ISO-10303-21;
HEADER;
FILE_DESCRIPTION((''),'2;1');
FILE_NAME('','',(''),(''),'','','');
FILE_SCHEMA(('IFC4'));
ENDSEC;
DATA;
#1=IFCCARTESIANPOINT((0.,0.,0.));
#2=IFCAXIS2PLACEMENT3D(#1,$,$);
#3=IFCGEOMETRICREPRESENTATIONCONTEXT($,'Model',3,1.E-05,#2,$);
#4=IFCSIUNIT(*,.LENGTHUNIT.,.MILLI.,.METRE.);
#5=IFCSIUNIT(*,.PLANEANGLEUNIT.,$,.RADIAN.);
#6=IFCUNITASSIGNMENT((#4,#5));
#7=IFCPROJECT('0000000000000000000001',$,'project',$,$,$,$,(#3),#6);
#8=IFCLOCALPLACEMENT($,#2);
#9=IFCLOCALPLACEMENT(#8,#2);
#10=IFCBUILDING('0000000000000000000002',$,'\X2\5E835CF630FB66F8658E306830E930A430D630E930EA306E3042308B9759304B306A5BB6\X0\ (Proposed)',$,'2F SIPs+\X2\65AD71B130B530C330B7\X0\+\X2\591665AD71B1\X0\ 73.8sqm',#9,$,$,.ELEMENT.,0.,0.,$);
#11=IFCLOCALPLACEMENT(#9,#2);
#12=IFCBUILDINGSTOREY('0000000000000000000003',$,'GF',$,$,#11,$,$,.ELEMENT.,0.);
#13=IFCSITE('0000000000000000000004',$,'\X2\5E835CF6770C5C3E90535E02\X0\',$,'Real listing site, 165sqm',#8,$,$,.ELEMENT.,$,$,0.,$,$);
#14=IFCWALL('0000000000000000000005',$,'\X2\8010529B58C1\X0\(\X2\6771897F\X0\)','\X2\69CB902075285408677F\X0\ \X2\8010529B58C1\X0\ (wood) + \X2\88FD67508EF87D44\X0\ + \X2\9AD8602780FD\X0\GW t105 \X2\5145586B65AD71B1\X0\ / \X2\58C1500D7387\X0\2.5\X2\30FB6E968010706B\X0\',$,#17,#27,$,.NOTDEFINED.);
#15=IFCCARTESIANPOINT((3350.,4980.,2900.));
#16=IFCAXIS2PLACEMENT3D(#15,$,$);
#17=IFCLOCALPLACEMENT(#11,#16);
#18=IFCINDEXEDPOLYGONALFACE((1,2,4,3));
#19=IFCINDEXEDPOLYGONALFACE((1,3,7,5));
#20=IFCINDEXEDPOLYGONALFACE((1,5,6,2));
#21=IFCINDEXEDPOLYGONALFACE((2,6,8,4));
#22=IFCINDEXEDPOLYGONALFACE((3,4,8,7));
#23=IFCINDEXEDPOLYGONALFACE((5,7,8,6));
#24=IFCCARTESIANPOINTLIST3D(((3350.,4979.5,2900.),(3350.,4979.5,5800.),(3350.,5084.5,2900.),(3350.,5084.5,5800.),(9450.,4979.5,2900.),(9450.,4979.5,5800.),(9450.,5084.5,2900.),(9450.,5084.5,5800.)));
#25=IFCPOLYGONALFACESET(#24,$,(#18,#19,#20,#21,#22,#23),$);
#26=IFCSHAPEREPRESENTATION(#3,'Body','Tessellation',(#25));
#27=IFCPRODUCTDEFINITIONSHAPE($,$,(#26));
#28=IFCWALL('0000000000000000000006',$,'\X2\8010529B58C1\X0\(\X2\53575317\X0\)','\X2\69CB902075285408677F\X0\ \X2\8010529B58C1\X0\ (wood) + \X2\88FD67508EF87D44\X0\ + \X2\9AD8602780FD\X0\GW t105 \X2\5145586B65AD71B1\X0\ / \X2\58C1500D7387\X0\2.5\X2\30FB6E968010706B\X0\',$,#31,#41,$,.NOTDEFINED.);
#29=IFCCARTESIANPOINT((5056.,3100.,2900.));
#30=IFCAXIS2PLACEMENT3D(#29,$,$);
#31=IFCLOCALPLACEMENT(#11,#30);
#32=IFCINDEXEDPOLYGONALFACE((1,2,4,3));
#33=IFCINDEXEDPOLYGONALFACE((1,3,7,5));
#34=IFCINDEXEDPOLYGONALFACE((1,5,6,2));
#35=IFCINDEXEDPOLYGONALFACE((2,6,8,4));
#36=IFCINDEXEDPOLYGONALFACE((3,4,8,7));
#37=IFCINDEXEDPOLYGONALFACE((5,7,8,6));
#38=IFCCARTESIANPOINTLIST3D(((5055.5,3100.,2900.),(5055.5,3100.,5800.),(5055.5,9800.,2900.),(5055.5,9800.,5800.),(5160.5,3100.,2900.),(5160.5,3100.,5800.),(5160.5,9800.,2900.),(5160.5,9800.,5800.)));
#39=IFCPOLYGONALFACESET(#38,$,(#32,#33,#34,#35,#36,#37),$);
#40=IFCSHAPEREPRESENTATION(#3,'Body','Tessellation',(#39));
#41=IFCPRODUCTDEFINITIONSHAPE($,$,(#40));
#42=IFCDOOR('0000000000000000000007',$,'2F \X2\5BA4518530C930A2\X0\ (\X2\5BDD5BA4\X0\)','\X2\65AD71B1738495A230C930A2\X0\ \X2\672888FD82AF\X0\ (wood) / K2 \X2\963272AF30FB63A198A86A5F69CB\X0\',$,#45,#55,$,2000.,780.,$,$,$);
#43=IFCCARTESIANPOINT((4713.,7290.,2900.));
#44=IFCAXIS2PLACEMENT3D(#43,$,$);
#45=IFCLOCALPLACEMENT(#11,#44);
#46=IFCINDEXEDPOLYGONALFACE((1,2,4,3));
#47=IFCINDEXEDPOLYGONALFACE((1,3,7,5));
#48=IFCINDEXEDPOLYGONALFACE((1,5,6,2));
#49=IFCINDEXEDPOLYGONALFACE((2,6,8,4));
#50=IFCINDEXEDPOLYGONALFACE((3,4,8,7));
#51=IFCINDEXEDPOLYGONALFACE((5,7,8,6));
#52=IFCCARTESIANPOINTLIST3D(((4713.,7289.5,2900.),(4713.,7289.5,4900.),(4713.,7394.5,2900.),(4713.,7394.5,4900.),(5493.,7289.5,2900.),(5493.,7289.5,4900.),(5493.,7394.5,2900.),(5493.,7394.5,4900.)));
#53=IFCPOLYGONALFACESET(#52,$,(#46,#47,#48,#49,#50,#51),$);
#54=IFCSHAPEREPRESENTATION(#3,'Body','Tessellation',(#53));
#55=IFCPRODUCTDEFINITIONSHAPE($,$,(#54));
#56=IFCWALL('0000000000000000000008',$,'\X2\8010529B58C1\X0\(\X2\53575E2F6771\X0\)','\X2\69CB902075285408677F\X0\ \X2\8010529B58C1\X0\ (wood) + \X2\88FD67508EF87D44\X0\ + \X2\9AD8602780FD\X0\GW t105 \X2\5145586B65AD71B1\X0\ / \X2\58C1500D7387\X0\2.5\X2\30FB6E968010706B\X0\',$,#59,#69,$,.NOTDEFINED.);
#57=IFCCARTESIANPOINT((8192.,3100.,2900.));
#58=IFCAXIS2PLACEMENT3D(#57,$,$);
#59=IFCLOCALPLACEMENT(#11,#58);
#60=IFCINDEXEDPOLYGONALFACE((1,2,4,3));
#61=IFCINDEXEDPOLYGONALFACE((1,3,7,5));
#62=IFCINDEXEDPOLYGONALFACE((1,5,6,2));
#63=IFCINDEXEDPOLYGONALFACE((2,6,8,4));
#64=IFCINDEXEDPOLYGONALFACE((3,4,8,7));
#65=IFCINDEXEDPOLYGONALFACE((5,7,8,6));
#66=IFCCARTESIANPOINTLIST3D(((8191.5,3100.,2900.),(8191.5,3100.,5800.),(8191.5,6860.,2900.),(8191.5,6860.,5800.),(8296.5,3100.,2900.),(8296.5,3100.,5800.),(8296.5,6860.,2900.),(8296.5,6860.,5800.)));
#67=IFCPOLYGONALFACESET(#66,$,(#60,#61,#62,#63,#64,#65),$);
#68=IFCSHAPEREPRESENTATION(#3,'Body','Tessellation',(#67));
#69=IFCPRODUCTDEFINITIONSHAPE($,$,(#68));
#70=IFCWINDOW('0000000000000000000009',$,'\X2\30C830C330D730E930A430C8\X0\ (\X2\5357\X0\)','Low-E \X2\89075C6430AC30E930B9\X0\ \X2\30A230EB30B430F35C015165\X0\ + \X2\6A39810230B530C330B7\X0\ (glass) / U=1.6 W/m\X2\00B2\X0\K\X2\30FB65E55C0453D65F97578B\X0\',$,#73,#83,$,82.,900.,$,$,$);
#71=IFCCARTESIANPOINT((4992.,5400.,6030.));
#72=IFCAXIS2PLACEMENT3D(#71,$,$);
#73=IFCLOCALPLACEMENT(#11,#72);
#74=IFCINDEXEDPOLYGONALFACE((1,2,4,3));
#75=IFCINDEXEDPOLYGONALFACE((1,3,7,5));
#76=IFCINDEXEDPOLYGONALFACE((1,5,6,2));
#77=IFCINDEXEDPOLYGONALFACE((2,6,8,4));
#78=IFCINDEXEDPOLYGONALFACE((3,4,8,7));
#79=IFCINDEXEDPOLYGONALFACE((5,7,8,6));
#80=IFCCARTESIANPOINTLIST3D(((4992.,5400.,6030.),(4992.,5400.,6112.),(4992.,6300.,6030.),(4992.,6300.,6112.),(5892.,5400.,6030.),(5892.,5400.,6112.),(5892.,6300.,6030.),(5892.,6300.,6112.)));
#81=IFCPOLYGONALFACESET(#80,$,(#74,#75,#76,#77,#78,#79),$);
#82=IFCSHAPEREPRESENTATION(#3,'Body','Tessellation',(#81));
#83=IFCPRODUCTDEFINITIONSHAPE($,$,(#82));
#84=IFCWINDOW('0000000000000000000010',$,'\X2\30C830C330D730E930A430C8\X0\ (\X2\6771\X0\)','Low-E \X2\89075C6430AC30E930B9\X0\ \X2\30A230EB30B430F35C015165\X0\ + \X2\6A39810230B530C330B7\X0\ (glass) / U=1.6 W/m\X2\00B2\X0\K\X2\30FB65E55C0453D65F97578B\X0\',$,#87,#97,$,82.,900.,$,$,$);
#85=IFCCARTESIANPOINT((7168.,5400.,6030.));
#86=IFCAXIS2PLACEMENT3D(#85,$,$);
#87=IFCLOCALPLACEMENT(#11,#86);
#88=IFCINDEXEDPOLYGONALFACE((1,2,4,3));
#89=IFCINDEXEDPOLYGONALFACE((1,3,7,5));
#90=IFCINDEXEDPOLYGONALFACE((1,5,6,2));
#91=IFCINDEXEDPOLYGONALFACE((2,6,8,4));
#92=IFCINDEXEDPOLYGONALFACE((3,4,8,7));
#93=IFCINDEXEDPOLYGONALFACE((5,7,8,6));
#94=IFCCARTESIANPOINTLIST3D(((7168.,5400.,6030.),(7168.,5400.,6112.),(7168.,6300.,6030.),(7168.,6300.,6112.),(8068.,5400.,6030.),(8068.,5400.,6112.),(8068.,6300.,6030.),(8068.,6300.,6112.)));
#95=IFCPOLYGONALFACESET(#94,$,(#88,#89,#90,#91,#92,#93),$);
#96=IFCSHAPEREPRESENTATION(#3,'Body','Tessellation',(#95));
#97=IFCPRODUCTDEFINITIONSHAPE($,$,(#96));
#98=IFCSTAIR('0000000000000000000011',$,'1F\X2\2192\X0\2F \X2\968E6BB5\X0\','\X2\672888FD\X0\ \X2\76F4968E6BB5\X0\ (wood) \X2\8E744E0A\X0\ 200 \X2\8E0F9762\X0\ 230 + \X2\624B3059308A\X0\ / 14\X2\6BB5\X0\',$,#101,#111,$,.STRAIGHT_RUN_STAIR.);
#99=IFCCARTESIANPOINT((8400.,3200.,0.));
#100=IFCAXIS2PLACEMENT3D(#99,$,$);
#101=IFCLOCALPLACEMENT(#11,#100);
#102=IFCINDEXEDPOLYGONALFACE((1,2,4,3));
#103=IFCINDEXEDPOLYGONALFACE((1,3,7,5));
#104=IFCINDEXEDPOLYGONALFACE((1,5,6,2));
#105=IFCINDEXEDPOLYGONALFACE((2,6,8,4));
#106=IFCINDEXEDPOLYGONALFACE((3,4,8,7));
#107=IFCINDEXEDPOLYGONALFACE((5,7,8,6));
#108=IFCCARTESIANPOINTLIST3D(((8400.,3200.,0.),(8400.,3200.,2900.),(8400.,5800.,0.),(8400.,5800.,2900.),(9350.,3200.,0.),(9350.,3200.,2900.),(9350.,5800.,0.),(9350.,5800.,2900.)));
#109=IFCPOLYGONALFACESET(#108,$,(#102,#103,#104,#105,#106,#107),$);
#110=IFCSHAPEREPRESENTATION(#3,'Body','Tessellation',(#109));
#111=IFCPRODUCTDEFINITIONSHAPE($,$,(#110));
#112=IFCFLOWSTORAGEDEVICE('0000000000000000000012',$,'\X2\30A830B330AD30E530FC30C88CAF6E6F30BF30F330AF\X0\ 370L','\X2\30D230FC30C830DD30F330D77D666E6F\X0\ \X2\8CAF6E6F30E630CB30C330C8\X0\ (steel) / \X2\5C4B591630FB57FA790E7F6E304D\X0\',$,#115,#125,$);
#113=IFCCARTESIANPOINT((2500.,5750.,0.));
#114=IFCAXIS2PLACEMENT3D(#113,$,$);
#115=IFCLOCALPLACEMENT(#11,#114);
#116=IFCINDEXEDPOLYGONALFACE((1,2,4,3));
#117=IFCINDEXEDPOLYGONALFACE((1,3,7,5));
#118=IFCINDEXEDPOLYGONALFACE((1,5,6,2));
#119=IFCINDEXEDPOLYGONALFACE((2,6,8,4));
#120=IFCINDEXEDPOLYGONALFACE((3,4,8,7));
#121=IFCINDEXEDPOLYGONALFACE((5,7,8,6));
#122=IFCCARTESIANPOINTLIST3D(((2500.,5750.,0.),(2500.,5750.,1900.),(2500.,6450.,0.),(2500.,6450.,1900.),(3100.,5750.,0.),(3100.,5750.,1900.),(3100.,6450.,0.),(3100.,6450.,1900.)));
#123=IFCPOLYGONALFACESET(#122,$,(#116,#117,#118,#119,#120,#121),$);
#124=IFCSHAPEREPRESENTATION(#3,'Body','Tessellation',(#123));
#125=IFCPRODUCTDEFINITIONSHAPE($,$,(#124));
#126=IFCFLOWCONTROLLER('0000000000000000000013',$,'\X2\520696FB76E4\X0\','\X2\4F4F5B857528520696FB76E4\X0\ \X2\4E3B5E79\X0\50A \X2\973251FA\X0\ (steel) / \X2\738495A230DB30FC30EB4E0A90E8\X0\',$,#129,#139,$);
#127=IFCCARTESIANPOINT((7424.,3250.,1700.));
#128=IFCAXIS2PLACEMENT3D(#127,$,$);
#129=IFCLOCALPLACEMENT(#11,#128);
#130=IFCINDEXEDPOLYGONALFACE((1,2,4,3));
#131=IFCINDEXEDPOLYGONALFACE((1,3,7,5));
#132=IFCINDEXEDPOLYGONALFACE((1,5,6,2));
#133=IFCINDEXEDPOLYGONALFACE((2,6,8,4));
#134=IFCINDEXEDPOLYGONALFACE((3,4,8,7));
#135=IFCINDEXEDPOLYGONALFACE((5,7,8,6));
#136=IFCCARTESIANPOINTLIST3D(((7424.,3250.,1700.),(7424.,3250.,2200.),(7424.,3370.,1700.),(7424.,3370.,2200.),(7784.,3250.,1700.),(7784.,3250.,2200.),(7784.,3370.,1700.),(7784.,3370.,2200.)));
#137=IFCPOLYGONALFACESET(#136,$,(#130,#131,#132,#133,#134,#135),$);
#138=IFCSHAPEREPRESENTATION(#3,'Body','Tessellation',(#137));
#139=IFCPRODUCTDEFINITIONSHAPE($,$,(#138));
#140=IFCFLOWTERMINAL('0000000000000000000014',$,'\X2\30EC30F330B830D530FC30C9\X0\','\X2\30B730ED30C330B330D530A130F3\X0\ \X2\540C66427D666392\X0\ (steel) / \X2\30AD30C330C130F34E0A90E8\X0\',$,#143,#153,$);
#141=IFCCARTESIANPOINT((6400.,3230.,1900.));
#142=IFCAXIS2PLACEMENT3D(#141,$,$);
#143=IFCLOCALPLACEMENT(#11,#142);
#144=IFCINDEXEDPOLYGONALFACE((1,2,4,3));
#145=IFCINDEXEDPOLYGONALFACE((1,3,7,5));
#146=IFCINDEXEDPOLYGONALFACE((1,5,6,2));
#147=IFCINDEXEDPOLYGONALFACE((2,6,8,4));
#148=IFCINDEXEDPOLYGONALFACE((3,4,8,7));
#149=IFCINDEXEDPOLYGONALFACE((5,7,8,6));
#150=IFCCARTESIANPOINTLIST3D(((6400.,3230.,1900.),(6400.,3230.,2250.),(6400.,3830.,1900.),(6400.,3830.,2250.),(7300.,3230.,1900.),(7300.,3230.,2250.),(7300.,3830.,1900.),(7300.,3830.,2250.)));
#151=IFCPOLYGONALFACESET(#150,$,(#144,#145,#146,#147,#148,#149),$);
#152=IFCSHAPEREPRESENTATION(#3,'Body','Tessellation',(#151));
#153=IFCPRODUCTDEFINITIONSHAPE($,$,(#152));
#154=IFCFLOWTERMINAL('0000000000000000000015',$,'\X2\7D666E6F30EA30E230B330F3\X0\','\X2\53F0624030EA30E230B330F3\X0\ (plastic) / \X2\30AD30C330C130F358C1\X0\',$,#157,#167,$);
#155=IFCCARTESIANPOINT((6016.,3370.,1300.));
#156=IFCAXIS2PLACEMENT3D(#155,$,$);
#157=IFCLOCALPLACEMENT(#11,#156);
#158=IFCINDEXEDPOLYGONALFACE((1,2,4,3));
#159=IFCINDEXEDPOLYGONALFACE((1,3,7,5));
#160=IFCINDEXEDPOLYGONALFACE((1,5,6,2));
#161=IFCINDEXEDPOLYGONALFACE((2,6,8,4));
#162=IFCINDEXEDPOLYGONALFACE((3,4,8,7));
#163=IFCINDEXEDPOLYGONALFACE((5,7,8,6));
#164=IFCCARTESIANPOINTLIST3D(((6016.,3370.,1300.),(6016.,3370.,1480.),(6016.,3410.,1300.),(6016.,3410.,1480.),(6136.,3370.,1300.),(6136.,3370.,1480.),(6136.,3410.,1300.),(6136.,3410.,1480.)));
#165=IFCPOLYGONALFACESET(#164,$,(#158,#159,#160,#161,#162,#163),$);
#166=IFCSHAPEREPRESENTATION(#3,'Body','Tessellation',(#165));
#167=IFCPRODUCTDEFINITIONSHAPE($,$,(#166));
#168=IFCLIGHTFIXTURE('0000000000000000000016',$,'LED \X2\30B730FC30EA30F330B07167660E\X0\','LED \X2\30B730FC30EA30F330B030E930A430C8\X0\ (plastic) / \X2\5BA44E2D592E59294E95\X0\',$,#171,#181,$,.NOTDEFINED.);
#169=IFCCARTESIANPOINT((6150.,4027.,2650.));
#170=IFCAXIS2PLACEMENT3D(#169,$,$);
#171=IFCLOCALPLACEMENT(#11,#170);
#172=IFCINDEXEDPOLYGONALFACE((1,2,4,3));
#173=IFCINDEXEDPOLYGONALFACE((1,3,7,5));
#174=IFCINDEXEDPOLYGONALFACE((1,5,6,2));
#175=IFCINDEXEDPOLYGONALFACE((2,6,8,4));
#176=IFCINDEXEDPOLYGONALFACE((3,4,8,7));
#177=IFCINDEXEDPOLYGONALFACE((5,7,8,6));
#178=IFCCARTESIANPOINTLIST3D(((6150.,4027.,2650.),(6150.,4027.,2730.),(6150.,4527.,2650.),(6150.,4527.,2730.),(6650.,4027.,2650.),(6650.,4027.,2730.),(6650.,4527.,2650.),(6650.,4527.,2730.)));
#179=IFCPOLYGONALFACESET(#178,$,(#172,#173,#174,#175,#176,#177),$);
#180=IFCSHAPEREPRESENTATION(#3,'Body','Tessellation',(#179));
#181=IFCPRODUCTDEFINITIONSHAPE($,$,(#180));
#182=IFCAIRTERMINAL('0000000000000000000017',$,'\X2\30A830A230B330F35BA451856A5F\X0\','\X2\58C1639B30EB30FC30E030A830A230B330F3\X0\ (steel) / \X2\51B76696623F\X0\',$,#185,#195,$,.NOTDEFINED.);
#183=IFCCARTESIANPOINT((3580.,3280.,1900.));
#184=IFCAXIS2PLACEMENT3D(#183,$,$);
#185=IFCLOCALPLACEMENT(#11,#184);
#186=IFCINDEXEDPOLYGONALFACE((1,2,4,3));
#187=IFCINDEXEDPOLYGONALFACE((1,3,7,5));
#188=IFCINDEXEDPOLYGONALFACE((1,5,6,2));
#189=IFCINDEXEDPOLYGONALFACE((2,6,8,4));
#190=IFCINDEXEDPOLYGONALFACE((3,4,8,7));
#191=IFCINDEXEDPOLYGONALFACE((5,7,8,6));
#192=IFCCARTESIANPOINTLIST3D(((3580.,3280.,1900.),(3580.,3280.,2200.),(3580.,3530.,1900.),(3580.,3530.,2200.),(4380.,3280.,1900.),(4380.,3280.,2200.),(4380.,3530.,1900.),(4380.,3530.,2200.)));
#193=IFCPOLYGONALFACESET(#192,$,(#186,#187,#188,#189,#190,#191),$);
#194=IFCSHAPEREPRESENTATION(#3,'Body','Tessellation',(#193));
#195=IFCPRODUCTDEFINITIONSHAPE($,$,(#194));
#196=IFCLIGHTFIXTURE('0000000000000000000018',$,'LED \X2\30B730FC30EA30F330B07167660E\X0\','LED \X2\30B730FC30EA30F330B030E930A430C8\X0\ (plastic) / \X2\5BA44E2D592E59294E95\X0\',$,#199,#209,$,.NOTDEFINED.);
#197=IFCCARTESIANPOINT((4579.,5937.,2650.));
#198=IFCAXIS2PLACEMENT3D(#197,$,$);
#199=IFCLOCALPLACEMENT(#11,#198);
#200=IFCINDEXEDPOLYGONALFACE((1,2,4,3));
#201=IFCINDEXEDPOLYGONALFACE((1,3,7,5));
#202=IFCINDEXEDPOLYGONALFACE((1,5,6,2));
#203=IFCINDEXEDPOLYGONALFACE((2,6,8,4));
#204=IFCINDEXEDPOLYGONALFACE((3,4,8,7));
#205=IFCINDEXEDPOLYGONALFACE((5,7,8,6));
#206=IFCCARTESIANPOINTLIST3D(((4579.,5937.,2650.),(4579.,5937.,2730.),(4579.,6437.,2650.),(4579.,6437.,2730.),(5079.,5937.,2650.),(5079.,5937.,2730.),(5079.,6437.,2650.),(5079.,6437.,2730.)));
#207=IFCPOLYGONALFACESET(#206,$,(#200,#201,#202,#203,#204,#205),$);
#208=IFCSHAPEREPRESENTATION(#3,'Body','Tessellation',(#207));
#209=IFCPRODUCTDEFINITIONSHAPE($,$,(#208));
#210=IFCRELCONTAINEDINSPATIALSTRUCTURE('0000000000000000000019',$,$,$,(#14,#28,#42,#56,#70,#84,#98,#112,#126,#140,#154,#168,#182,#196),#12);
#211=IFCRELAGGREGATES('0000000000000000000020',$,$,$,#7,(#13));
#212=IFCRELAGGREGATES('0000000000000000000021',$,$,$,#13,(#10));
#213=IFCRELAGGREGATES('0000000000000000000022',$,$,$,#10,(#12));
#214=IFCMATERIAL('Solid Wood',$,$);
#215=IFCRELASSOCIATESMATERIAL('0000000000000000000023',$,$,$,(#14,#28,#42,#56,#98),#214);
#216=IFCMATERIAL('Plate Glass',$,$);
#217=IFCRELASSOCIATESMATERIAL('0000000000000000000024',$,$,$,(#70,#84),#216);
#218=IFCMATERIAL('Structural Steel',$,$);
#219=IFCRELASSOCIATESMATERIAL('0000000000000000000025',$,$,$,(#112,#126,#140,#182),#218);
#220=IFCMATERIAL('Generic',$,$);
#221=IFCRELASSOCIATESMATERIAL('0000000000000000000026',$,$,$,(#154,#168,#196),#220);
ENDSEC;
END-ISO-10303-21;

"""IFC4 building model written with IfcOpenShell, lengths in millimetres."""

from ifc_helpers import new_model, si_unit, frame, frame_2d, origin, place, context, project, spatial, rectangle, extrude, material, element, fill, save


model = new_model("IFC4")

# Units and contexts
model_context = context("Model", 3, precision=1e-05, world=origin())
ifc_project = project(units=[si_unit("LENGTHUNIT", "METRE", prefix="MILLI"), si_unit("PLANEANGLEUNIT", "RADIAN")], contexts=[model_context])

# Site, building, storey
site_placement = place(None, origin())
site = spatial("IfcSite", under=ifc_project, at=site_placement, Name="広島県尾道市", ObjectType="Real listing site, 165sqm", CompositionType="ELEMENT", RefElevation=0.0)
building_placement = place(site_placement, origin())
building = spatial("IfcBuilding", under=site, at=building_placement, Name="広島・書斎とライブラリのある静かな家 (Proposed)", ObjectType="2F SIPs+断熱サッシ+外断熱 73.8sqm", CompositionType="ELEMENT", ElevationOfRefHeight=0.0, ElevationOfTerrain=0.0)
storey_placement = place(building_placement, origin())
storey = spatial("IfcBuildingStorey", under=building, at=storey_placement, Name="GF", CompositionType="ELEMENT", Elevation=0.0)

# Shared definitions
ifc_material_1 = material(Name="Solid Wood")

# Wall
wall_1_placement = place(storey_placement, frame((3350.0, 4980.0, 2900.0)))
element("IfcWall", 1, at=wall_1_placement, inside=storey, material=ifc_material_1, Name="耐力壁(東西)", Description="構造用合板 耐力壁 (wood) + 製材軸組 + 高性能GW t105 充填断熱 / 壁倍率2.5・準耐火", PredefinedType="NOTDEFINED", context=model_context, shape_type="SweptSolid", body=[
    extrude(rectangle(XDim=6100.0, YDim=105.0, at=frame_2d((3050.0, 52.0))), frame((3350.0, 4980.0, 2900.0)), (0.0, 0.0, 1.0), 2900.0),
])

# Wall, opening, door
wall_2_placement = place(storey_placement, frame((5056.0, 3100.0, 2900.0)))
wall_2 = element("IfcWall", 2, at=wall_2_placement, inside=storey, material=ifc_material_1, Name="耐力壁(南北)", Description="構造用合板 耐力壁 (wood) + 製材軸組 + 高性能GW t105 充填断熱 / 壁倍率2.5・準耐火", PredefinedType="NOTDEFINED", context=model_context, shape_type="SweptSolid", body=[
    extrude(rectangle(XDim=105.0, YDim=6700.0, at=frame_2d((52.0, 3350.0))), frame((5056.0, 3100.0, 2900.0)), (0.0, 0.0, 1.0), 2900.0),
])
opening_placement = place(storey_placement, frame((4713.0, 7290.0, 2900.0)))
opening = element("IfcOpeningElement", 3, at=opening_placement, cuts=wall_2, PredefinedType="NOTDEFINED", context=model_context, shape_type="SweptSolid", body=[
    extrude(rectangle(XDim=780.0, YDim=105.0, at=frame_2d((390.0, 52.0))), frame((4713.0, 7290.0, 2900.0)), (0.0, 0.0, 1.0), 2000.0),
])
door_placement = place(storey_placement, frame((4713.0, 7290.0, 2900.0)))
door = element("IfcDoor", 4, at=door_placement, inside=storey, material=ifc_material_1, Name="2F 室内ドア (寝室)", Description="断熱玄関ドア 木製芯 (wood) / K2 防犯・採風機構", OverallHeight=2000.0, OverallWidth=780.0, context=model_context, shape_type="SweptSolid", body=[
    extrude(rectangle(XDim=780.0, YDim=105.0, at=frame_2d((390.0, 52.0))), frame((4713.0, 7290.0, 2900.0)), (0.0, 0.0, 1.0), 2000.0),
])
fill(opening, door)

# Wall
wall_3_placement = place(storey_placement, frame((8192.0, 3100.0, 2900.0)))
element("IfcWall", 5, at=wall_3_placement, inside=storey, material=ifc_material_1, Name="耐力壁(南帯東)", Description="構造用合板 耐力壁 (wood) + 製材軸組 + 高性能GW t105 充填断熱 / 壁倍率2.5・準耐火", PredefinedType="NOTDEFINED", context=model_context, shape_type="SweptSolid", body=[
    extrude(rectangle(XDim=105.0, YDim=3760.0, at=frame_2d((52.0, 1880.0))), frame((8192.0, 3100.0, 2900.0)), (0.0, 0.0, 1.0), 2900.0),
])

# Windows
ifc_material_2 = material(Name="Plate Glass")
window_1_placement = place(storey_placement, frame((4992.0, 5400.0, 6030.0)))
element("IfcWindow", 6, at=window_1_placement, inside=storey, material=ifc_material_2, Name="トップライト (南)", Description="Low-E 複層ガラス アルゴン封入 + 樹脂サッシ (glass) / U=1.6 W/m²K・日射取得型", OverallHeight=82.0, OverallWidth=900.0, context=model_context, shape_type="SweptSolid", body=[
    extrude(rectangle(XDim=900.0, YDim=900.0, at=frame_2d((450.0, 450.0))), frame((4992.0, 5400.0, 6030.0)), (0.0, 0.0, 1.0), 82.0),
])
window_2_placement = place(storey_placement, frame((7168.0, 5400.0, 6030.0)))
element("IfcWindow", 7, at=window_2_placement, inside=storey, material=ifc_material_2, Name="トップライト (東)", Description="Low-E 複層ガラス アルゴン封入 + 樹脂サッシ (glass) / U=1.6 W/m²K・日射取得型", OverallHeight=82.0, OverallWidth=900.0, context=model_context, shape_type="SweptSolid", body=[
    extrude(rectangle(XDim=900.0, YDim=900.0, at=frame_2d((450.0, 450.0))), frame((7168.0, 5400.0, 6030.0)), (0.0, 0.0, 1.0), 82.0),
])

# Stair
stair_placement = place(storey_placement, frame((8400.0, 3200.0, 0.0)))
element("IfcStair", 8, at=stair_placement, inside=storey, material=ifc_material_1, Name="1F→2F 階段", Description="木製 直階段 (wood) 蹴上 200 踏面 230 + 手すり / 14段", PredefinedType="STRAIGHT_RUN_STAIR", context=model_context, shape_type="SweptSolid", body=[
    extrude(rectangle(XDim=950.0, YDim=2600.0, at=frame_2d((475.0, 1300.0))), frame((8400.0, 3200.0, 0.0)), (0.0, 0.0, 1.0), 2900.0),
])

# Flow storage device
ifc_material_3 = material(Name="Structural Steel")
flow_storage_device_placement = place(storey_placement, frame((2500.0, 5750.0, 0.0)))
element("IfcFlowStorageDevice", 9, at=flow_storage_device_placement, inside=storey, material=ifc_material_3, Name="エコキュート貯湯タンク 370L", Description="ヒートポンプ給湯 貯湯ユニット (steel) / 屋外・基礎置き", context=model_context, shape_type="SweptSolid", body=[
    extrude(rectangle(XDim=600.0, YDim=700.0, at=frame_2d((300.0, 350.0))), frame((2500.0, 5750.0, 0.0)), (0.0, 0.0, 1.0), 1900.0),
])

# Flow controller
flow_controller_placement = place(storey_placement, frame((7424.0, 3250.0, 1700.0)))
element("IfcFlowController", 10, at=flow_controller_placement, inside=storey, material=ifc_material_3, Name="分電盤", Description="住宅用分電盤 主幹50A 露出 (steel) / 玄関ホール上部", context=model_context, shape_type="SweptSolid", body=[
    extrude(rectangle(XDim=360.0, YDim=120.0, at=frame_2d((180.0, 60.0))), frame((7424.0, 3250.0, 1700.0)), (0.0, 0.0, 1.0), 500.0),
])

# Flow terminals
flow_terminal_1_placement = place(storey_placement, frame((6400.0, 3230.0, 1900.0)))
element("IfcFlowTerminal", 11, at=flow_terminal_1_placement, inside=storey, material=ifc_material_3, Name="レンジフード", Description="シロッコファン 同時給排 (steel) / キッチン上部", context=model_context, shape_type="SweptSolid", body=[
    extrude(rectangle(XDim=900.0, YDim=600.0, at=frame_2d((450.0, 300.0))), frame((6400.0, 3230.0, 1900.0)), (0.0, 0.0, 1.0), 350.0),
])
ifc_material_4 = material(Name="Generic")
flow_terminal_2_placement = place(storey_placement, frame((6016.0, 3370.0, 1300.0)))
element("IfcFlowTerminal", 12, at=flow_terminal_2_placement, inside=storey, material=ifc_material_4, Name="給湯リモコン", Description="台所リモコン (plastic) / キッチン壁", context=model_context, shape_type="SweptSolid", body=[
    extrude(rectangle(XDim=120.0, YDim=40.0, at=frame_2d((60.0, 20.0))), frame((6016.0, 3370.0, 1300.0)), (0.0, 0.0, 1.0), 180.0),
])

# Light fixture
light_fixture_1_placement = place(storey_placement, frame((6150.0, 4027.0, 2650.0)))
element("IfcLightFixture", 13, at=light_fixture_1_placement, inside=storey, material=ifc_material_4, Name="LED シーリング照明", Description="LED シーリングライト (plastic) / 室中央天井", PredefinedType="NOTDEFINED", context=model_context, shape_type="SweptSolid", body=[
    extrude(rectangle(XDim=500.0, YDim=500.0, at=frame_2d((250.0, 250.0))), frame((6150.0, 4027.0, 2650.0)), (0.0, 0.0, 1.0), 80.0),
])

# Air terminal
air_terminal_1_placement = place(storey_placement, frame((3580.0, 3280.0, 1900.0)))
element("IfcAirTerminal", 14, at=air_terminal_1_placement, inside=storey, material=ifc_material_3, Name="エアコン室内機", Description="壁掛ルームエアコン (steel) / 冷暖房", PredefinedType="NOTDEFINED", context=model_context, shape_type="SweptSolid", body=[
    extrude(rectangle(XDim=800.0, YDim=250.0, at=frame_2d((400.0, 125.0))), frame((3580.0, 3280.0, 1900.0)), (0.0, 0.0, 1.0), 300.0),
])

# Light fixture
light_fixture_2_placement = place(storey_placement, frame((4579.0, 5937.0, 2650.0)))
element("IfcLightFixture", 15, at=light_fixture_2_placement, inside=storey, material=ifc_material_4, Name="LED シーリング照明", Description="LED シーリングライト (plastic) / 室中央天井", PredefinedType="NOTDEFINED", context=model_context, shape_type="SweptSolid", body=[
    extrude(rectangle(XDim=500.0, YDim=500.0, at=frame_2d((250.0, 250.0))), frame((4579.0, 5937.0, 2650.0)), (0.0, 0.0, 1.0), 80.0),
])

save(model, "model.ifc")
